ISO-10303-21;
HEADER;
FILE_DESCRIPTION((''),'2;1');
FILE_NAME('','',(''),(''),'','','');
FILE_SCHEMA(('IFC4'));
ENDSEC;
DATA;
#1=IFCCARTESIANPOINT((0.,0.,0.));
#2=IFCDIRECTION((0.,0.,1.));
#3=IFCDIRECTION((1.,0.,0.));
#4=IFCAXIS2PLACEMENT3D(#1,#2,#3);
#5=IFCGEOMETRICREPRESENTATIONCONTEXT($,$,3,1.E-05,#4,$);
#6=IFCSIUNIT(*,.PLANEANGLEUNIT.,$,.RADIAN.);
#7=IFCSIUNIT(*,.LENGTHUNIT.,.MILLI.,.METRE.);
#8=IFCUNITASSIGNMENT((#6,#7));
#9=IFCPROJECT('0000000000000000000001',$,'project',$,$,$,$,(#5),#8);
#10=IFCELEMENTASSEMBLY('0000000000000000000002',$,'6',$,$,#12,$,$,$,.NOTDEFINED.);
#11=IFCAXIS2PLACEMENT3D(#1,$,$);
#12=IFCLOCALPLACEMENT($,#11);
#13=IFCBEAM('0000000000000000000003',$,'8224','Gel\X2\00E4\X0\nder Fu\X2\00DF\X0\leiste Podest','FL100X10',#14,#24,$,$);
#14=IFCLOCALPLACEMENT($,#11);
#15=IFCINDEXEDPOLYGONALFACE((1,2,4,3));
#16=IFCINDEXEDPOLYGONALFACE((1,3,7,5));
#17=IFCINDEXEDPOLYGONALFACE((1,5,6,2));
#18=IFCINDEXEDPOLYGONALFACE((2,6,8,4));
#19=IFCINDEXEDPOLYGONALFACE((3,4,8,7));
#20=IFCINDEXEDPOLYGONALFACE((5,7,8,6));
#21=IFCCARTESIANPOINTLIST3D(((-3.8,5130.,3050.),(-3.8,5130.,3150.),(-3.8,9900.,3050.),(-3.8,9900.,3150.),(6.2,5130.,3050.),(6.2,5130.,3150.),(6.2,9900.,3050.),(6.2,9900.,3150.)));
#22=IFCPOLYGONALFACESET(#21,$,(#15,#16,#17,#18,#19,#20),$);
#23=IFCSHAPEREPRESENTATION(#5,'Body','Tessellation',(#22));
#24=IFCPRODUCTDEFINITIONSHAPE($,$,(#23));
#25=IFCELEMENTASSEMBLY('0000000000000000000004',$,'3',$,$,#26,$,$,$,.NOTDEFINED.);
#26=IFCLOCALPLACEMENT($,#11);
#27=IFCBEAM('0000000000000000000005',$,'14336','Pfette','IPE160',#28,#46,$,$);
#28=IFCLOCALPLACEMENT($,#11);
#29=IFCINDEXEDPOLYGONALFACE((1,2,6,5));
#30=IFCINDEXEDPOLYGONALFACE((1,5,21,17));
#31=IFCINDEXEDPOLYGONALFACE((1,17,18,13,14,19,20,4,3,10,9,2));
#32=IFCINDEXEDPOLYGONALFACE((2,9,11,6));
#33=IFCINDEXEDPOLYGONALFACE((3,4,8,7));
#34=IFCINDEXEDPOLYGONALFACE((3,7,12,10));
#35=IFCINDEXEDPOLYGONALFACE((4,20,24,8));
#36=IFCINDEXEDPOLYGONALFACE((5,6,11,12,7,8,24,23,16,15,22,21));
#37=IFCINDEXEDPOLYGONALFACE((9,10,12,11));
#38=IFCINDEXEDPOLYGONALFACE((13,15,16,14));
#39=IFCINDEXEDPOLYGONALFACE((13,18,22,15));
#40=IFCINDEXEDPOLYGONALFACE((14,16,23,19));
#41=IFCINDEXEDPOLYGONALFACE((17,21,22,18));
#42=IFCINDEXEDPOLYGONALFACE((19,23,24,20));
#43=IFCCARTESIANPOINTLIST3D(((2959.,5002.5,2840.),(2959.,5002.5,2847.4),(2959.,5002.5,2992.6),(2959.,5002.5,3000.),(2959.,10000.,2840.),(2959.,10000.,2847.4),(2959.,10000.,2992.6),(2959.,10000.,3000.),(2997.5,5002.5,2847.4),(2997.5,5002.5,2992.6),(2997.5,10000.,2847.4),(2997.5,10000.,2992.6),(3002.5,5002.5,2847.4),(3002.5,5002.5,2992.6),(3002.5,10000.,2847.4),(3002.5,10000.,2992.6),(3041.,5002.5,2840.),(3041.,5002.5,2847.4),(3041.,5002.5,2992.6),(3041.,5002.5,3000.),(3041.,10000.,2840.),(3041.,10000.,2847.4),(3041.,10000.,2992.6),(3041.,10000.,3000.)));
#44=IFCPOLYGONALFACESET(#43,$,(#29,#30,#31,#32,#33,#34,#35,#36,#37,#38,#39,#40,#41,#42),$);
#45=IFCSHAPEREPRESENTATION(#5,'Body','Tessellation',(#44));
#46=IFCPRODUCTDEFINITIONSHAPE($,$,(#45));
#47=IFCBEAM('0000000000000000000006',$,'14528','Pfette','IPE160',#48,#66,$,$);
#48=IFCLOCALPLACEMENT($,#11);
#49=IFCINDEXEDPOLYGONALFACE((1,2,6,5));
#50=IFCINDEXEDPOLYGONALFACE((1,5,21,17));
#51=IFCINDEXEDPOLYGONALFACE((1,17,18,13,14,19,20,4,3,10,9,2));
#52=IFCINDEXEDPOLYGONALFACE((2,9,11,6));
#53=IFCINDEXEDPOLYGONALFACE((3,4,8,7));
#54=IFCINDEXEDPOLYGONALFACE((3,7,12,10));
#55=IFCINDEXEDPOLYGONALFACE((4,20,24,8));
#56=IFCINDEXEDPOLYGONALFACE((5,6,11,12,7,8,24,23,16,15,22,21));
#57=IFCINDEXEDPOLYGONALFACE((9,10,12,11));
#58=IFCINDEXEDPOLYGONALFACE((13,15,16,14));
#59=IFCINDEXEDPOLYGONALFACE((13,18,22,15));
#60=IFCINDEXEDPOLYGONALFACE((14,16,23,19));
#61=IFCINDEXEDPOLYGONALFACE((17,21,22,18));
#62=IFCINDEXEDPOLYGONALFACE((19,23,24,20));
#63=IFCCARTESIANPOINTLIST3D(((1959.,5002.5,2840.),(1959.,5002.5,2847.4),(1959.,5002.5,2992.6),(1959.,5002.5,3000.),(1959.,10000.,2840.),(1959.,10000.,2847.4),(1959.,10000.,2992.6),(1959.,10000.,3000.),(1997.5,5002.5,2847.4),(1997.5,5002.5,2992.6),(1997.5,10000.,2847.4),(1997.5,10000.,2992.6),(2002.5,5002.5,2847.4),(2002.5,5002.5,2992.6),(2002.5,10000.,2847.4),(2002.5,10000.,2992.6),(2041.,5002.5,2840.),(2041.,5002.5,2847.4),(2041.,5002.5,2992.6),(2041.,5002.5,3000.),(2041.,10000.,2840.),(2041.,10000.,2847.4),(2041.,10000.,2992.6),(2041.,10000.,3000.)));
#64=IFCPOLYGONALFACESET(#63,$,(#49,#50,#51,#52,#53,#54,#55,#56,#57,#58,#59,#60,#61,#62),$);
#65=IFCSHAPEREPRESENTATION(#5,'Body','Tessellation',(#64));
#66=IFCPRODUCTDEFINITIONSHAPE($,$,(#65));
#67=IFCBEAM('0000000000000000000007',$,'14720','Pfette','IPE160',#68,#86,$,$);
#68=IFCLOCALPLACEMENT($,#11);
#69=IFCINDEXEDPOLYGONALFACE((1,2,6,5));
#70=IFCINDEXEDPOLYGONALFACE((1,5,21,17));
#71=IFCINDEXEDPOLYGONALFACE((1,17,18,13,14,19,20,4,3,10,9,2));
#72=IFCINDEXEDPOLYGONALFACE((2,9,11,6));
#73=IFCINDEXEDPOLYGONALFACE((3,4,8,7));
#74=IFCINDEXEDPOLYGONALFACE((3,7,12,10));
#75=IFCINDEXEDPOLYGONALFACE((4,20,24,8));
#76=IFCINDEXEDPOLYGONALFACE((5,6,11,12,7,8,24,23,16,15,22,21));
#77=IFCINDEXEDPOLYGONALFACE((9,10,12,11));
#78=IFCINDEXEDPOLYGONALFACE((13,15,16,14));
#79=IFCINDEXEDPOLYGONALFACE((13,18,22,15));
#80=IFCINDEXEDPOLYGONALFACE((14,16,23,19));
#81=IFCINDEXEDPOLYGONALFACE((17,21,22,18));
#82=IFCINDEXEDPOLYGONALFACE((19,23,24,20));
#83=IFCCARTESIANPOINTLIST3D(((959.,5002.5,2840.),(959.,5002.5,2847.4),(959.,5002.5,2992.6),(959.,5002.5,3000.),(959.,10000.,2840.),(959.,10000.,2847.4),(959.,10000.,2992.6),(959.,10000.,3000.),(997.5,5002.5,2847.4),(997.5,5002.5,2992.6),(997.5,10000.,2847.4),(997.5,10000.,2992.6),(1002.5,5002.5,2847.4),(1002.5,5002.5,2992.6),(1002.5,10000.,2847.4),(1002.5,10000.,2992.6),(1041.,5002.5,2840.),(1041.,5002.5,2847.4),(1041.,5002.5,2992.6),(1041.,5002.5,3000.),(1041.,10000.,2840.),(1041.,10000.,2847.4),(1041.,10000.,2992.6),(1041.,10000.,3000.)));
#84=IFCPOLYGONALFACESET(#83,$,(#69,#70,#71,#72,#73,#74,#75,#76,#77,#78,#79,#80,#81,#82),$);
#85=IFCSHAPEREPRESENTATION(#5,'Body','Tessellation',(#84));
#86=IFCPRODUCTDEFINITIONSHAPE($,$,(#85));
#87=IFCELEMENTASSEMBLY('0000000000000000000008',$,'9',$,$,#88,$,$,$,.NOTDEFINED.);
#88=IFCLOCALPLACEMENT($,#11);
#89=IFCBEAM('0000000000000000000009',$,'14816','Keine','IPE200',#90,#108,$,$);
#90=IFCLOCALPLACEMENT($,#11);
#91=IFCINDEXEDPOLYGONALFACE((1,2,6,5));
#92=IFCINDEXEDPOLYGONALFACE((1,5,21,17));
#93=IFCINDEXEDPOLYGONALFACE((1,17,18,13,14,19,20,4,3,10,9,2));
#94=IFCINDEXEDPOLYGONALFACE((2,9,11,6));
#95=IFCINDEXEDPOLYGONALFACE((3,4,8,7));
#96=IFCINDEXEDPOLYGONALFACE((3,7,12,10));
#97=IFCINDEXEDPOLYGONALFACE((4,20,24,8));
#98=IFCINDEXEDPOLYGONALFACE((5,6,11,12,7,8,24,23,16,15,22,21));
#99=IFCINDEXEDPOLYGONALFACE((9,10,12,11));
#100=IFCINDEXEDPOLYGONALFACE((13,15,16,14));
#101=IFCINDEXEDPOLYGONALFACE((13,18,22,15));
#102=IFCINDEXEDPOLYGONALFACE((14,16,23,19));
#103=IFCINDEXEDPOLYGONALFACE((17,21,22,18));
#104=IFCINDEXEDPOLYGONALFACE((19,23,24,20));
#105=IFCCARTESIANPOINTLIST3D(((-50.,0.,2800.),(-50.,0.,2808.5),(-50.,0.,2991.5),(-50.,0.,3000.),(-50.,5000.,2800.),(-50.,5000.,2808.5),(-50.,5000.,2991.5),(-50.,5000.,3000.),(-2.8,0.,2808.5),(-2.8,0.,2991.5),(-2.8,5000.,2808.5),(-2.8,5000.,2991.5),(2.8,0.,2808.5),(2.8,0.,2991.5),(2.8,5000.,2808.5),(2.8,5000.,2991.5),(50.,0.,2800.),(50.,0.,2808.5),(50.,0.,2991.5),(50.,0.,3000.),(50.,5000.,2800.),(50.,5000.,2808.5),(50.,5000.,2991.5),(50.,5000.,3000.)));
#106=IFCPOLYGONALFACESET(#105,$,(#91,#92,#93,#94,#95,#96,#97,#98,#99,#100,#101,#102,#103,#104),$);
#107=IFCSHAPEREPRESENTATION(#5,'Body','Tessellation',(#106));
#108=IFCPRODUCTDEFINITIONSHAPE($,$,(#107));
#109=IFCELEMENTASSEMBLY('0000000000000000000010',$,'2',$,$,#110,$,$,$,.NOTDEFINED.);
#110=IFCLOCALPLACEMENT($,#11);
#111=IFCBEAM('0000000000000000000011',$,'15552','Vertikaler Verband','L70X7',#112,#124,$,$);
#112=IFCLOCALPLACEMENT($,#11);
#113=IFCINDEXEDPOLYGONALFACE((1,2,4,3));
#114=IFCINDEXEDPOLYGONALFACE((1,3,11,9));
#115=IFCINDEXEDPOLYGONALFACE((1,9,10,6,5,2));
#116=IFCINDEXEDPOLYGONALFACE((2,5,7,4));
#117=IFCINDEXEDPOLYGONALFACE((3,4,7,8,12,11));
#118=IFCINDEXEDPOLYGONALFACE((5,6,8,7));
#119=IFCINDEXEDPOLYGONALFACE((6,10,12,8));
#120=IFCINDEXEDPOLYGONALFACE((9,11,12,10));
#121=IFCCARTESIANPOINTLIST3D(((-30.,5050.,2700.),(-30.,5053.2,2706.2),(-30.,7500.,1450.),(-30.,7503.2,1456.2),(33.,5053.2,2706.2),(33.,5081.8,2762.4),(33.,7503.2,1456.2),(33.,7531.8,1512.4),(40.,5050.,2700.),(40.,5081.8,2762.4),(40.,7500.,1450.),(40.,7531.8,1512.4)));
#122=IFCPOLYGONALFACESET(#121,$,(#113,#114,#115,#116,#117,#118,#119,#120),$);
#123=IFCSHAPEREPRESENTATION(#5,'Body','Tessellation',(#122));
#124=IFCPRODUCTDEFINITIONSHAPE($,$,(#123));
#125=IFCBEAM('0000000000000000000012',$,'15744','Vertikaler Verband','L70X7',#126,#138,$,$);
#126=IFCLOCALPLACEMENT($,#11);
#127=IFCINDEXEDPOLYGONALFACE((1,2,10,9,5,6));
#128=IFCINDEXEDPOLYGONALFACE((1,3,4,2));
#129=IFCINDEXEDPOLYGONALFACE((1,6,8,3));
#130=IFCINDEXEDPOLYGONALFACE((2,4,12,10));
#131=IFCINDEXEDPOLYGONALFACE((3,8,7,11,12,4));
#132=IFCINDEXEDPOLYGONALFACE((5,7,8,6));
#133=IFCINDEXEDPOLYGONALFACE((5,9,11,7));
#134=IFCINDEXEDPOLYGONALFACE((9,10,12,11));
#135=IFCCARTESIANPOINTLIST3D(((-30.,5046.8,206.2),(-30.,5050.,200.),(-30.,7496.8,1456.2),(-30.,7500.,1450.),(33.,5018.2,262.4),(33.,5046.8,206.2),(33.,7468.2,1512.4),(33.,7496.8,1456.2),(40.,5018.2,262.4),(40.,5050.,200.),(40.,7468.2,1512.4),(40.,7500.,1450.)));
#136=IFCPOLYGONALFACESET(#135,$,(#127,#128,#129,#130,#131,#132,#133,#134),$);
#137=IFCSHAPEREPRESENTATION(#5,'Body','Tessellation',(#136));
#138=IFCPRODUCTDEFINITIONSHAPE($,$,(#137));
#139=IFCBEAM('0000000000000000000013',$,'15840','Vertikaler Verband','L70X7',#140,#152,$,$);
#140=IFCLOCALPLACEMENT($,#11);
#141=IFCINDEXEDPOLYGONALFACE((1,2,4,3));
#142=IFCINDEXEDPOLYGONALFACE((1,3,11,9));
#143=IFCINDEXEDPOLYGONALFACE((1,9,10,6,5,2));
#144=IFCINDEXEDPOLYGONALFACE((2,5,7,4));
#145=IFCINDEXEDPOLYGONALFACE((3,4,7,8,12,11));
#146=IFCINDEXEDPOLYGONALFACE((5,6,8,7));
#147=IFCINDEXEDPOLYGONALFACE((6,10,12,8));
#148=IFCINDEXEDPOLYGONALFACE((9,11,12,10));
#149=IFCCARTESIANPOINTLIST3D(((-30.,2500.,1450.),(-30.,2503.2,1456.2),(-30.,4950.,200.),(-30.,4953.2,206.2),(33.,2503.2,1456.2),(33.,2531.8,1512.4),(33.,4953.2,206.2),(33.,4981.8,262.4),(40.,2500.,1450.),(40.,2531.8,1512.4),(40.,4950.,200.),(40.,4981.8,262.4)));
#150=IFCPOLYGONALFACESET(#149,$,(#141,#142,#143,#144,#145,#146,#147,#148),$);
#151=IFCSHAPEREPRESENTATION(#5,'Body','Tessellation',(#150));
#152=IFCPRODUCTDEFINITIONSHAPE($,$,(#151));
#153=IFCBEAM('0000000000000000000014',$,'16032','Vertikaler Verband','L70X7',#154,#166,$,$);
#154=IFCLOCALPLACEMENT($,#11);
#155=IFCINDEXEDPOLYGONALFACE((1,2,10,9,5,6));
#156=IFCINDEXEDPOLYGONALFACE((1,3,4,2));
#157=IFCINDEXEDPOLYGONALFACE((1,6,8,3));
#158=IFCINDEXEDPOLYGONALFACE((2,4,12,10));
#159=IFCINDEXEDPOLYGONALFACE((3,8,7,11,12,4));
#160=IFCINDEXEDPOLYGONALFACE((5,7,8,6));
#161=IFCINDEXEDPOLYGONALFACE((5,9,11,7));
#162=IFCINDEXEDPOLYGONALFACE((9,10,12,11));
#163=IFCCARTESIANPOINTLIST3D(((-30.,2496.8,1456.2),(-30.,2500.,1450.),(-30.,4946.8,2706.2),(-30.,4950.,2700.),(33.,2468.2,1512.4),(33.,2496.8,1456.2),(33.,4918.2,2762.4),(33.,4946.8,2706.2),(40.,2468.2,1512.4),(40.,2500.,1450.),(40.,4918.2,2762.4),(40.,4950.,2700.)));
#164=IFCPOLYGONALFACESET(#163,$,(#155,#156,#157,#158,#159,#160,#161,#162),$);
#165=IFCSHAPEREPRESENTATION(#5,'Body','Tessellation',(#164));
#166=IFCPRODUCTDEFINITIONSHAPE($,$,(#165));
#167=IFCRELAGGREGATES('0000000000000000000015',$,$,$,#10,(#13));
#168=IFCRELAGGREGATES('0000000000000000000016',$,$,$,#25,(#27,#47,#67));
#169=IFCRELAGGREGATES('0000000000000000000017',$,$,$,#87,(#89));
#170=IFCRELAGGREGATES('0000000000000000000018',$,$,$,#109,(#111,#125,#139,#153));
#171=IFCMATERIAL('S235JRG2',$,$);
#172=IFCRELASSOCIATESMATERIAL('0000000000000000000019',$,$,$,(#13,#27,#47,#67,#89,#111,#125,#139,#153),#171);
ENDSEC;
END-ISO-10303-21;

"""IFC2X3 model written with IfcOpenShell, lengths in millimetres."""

from ifc_helpers import new_model, si_unit, frame, origin_with_axes, place, context, project, polyline, outline, extrude, material, element, aggregate, save


model = new_model("IFC2X3")

# Units and contexts
context_of_model = context(None, 3, precision=1e-05, world=origin_with_axes())
ifc_project = project(units=[si_unit("PLANEANGLEUNIT", "RADIAN"), si_unit("LENGTHUNIT", "METRE", prefix="MILLI")], contexts=[context_of_model])

# Element assembly, beam
assembly_1_placement = place(None, frame((1.2, 5130.0, 6100.0), z_axis=(0.0, 0.0, 1.0), x_axis=(0.0, 1.0, 0.0)))
assembly_1 = element("IfcElementAssembly", 1, at=assembly_1_placement, Name="6", PredefinedType="NOTDEFINED")
ifc_material = material(Name="S235JRG2")
placement_1 = place(None, frame((1.2, 5130.0, 3100.0), z_axis=(0.0, 0.0, 1.0), x_axis=(0.0, 1.0, 0.0)))
beam_1_placement = place(placement_1, origin_with_axes())
beam_1 = element("IfcBeam", 2, at=beam_1_placement, material=ifc_material, Name="8224", Description="Geländer Fußleiste Podest", ObjectType="FL100X10", context=context_of_model, shape_type="SweptSolid", body=[
    extrude(outline(polyline([(5.0, -50.0), (5.0, 50.0), (-5.0, 50.0), (-5.0, -50.0), (5.0, -50.0), (5.0, -50.0)])), frame((0.0, 0.0, 0.0), z_axis=(1.0, 0.0, 0.0), x_axis=(0.0, 1.0, 0.0)), (0.0, 0.0, 1.0), 4770.0),
])
aggregate(assembly_1, [beam_1])

# Element assembly, beams
assembly_2_placement = place(None, frame((1000.0, 5002.5, 6000.0), z_axis=(0.0, 0.0, 1.0), x_axis=(0.0, 1.0, 0.0)))
assembly_2 = element("IfcElementAssembly", 3, at=assembly_2_placement, Name="3", PredefinedType="NOTDEFINED")
placement_2 = place(None, frame((3000.0, 5002.5, 2920.0), z_axis=(0.0, 0.0, 1.0), x_axis=(0.0, 1.0, 0.0)))
beam_2_placement = place(placement_2, origin_with_axes())
beam_2 = element("IfcBeam", 4, at=beam_2_placement, material=ifc_material, Name="14336", Description="Pfette", ObjectType="IPE160", context=context_of_model, shape_type="SweptSolid", body=[
    extrude(outline(polyline([(41.0, -80.0), (41.0, -72.6), (2.5, -72.6), (2.5, 72.6), (41.0, 72.6), (41.0, 80.0), (-41.0, 80.0), (-41.0, 72.6), (-2.5, 72.6), (-2.5, -72.6), (-41.0, -72.6), (-41.0, -80.0), (41.0, -80.0), (41.0, -80.0)])), frame((0.0, 0.0, 0.0), z_axis=(1.0, 0.0, 0.0), x_axis=(0.0, 1.0, 0.0)), (0.0, 0.0, 1.0), 4997.5),
])
placement_3 = place(None, frame((2000.0, 5002.5, 2920.0), z_axis=(0.0, 0.0, 1.0), x_axis=(0.0, 1.0, 0.0)))
beam_3_placement = place(placement_3, origin_with_axes())
beam_3 = element("IfcBeam", 5, at=beam_3_placement, material=ifc_material, Name="14528", Description="Pfette", ObjectType="IPE160", context=context_of_model, shape_type="SweptSolid", body=[
    extrude(outline(polyline([(41.0, -80.0), (41.0, -72.6), (2.5, -72.6), (2.5, 72.6), (41.0, 72.6), (41.0, 80.0), (-41.0, 80.0), (-41.0, 72.6), (-2.5, 72.6), (-2.5, -72.6), (-41.0, -72.6), (-41.0, -80.0), (41.0, -80.0), (41.0, -80.0)])), frame((0.0, 0.0, 0.0), z_axis=(1.0, 0.0, 0.0), x_axis=(0.0, 1.0, 0.0)), (0.0, 0.0, 1.0), 4997.5),
])
placement_4 = place(None, frame((1000.0, 5002.5, 2920.0), z_axis=(0.0, 0.0, 1.0), x_axis=(0.0, 1.0, 0.0)))
beam_4_placement = place(placement_4, origin_with_axes())
beam_4 = element("IfcBeam", 6, at=beam_4_placement, material=ifc_material, Name="14720", Description="Pfette", ObjectType="IPE160", context=context_of_model, shape_type="SweptSolid", body=[
    extrude(outline(polyline([(41.0, -80.0), (41.0, -72.6), (2.5, -72.6), (2.5, 72.6), (41.0, 72.6), (41.0, 80.0), (-41.0, 80.0), (-41.0, 72.6), (-2.5, 72.6), (-2.5, -72.6), (-41.0, -72.6), (-41.0, -80.0), (41.0, -80.0), (41.0, -80.0)])), frame((0.0, 0.0, 0.0), z_axis=(1.0, 0.0, 0.0), x_axis=(0.0, 1.0, 0.0)), (0.0, 0.0, 1.0), 4997.5),
])
aggregate(assembly_2, [beam_2, beam_3, beam_4])

# Element assembly, beam
assembly_3_placement = place(None, frame((5000.0, 10000.0, 6000.0), z_axis=(0.0, 0.0, 1.0), x_axis=(0.0, -1.0, 0.0)))
assembly_3 = element("IfcElementAssembly", 7, at=assembly_3_placement, Name="9", PredefinedType="NOTDEFINED")
placement_5 = place(None, frame((0.0, 5000.0, 2900.0), z_axis=(0.0, 0.0, 1.0), x_axis=(0.0, -1.0, 0.0)))
beam_5_placement = place(placement_5, origin_with_axes())
beam_5 = element("IfcBeam", 8, at=beam_5_placement, material=ifc_material, Name="14816", Description="Keine", ObjectType="IPE200", context=context_of_model, shape_type="SweptSolid", body=[
    extrude(outline(polyline([(50.0, -100.0), (50.0, -91.5), (2.8, -91.5), (2.8, 91.5), (50.0, 91.5), (50.0, 100.0), (-50.0, 100.0), (-50.0, 91.5), (-2.8, 91.5), (-2.8, -91.5), (-50.0, -91.5), (-50.0, -100.0), (50.0, -100.0), (50.0, -100.0)])), frame((0.0, 0.0, 0.0), z_axis=(1.0, 0.0, 0.0), x_axis=(0.0, 1.0, 0.0)), (0.0, 0.0, 1.0), 5000.0),
])
aggregate(assembly_3, [beam_5])

# Element assembly, beams
assembly_4_placement = place(None, frame((40.0, 7500.0, 1450.0), z_axis=(0.0, 0.45447, 0.890762), x_axis=(0.0, 0.890762, -0.45447)))
assembly_4 = element("IfcElementAssembly", 9, at=assembly_4_placement, Name="2", PredefinedType="NOTDEFINED")
placement_6 = place(None, frame((20.3, 5059.0, 2717.5), z_axis=(0.0, 0.45447, 0.890762), x_axis=(0.0, 0.890762, -0.45447)))
beam_6_placement = place(placement_6, origin_with_axes())
beam_6 = element("IfcBeam", 10, at=beam_6_placement, material=ifc_material, Name="15552", Description="Vertikaler Verband", ObjectType="L70X7", context=context_of_model, shape_type="SweptSolid", body=[
    extrude(outline(polyline([(-19.7, 50.3), (-19.7, -19.7), (50.3, -19.7), (50.3, -12.7), (-12.7, -12.7), (-12.7, 50.3), (-19.7, 50.3), (-19.7, 50.3)])), frame((0.0, 0.0, 0.0), z_axis=(1.0, 0.0, 0.0), x_axis=(0.0, 1.0, 0.0)), (0.0, 0.0, 1.0), 2750.5),
])
placement_7 = place(None, frame((20.3, 5041.0, 217.5), z_axis=(0.0, -0.45447, 0.890762), x_axis=(0.0, 0.890762, 0.45447)))
beam_7_placement = place(placement_7, origin_with_axes())
beam_7 = element("IfcBeam", 11, at=beam_7_placement, material=ifc_material, Name="15744", Description="Vertikaler Verband", ObjectType="L70X7", context=context_of_model, shape_type="SweptSolid", body=[
    extrude(outline(polyline([(-19.7, 50.3), (-19.7, -19.7), (50.3, -19.7), (50.3, -12.7), (-12.7, -12.7), (-12.7, 50.3), (-19.7, 50.3), (-19.7, 50.3)])), frame((0.0, 0.0, 0.0), z_axis=(1.0, 0.0, 0.0), x_axis=(0.0, 1.0, 0.0)), (0.0, 0.0, 1.0), 2750.5),
])
placement_8 = place(None, frame((20.3, 2509.0, 1467.5), z_axis=(0.0, 0.45447, 0.890762), x_axis=(0.0, 0.890762, -0.45447)))
beam_8_placement = place(placement_8, origin_with_axes())
beam_8 = element("IfcBeam", 12, at=beam_8_placement, material=ifc_material, Name="15840", Description="Vertikaler Verband", ObjectType="L70X7", context=context_of_model, shape_type="SweptSolid", body=[
    extrude(outline(polyline([(-19.7, 50.3), (-19.7, -19.7), (50.3, -19.7), (50.3, -12.7), (-12.7, -12.7), (-12.7, 50.3), (-19.7, 50.3), (-19.7, 50.3)])), frame((0.0, 0.0, 0.0), z_axis=(1.0, 0.0, 0.0), x_axis=(0.0, 1.0, 0.0)), (0.0, 0.0, 1.0), 2750.5),
])
placement_9 = place(None, frame((20.3, 2491.0, 1467.5), z_axis=(0.0, -0.45447, 0.890762), x_axis=(0.0, 0.890762, 0.45447)))
beam_9_placement = place(placement_9, origin_with_axes())
beam_9 = element("IfcBeam", 13, at=beam_9_placement, material=ifc_material, Name="16032", Description="Vertikaler Verband", ObjectType="L70X7", context=context_of_model, shape_type="SweptSolid", body=[
    extrude(outline(polyline([(-19.7, 50.3), (-19.7, -19.7), (50.3, -19.7), (50.3, -12.7), (-12.7, -12.7), (-12.7, 50.3), (-19.7, 50.3), (-19.7, 50.3)])), frame((0.0, 0.0, 0.0), z_axis=(1.0, 0.0, 0.0), x_axis=(0.0, 1.0, 0.0)), (0.0, 0.0, 1.0), 2750.5),
])
aggregate(assembly_4, [beam_6, beam_7, beam_8, beam_9])

save(model, "model.ifc")
